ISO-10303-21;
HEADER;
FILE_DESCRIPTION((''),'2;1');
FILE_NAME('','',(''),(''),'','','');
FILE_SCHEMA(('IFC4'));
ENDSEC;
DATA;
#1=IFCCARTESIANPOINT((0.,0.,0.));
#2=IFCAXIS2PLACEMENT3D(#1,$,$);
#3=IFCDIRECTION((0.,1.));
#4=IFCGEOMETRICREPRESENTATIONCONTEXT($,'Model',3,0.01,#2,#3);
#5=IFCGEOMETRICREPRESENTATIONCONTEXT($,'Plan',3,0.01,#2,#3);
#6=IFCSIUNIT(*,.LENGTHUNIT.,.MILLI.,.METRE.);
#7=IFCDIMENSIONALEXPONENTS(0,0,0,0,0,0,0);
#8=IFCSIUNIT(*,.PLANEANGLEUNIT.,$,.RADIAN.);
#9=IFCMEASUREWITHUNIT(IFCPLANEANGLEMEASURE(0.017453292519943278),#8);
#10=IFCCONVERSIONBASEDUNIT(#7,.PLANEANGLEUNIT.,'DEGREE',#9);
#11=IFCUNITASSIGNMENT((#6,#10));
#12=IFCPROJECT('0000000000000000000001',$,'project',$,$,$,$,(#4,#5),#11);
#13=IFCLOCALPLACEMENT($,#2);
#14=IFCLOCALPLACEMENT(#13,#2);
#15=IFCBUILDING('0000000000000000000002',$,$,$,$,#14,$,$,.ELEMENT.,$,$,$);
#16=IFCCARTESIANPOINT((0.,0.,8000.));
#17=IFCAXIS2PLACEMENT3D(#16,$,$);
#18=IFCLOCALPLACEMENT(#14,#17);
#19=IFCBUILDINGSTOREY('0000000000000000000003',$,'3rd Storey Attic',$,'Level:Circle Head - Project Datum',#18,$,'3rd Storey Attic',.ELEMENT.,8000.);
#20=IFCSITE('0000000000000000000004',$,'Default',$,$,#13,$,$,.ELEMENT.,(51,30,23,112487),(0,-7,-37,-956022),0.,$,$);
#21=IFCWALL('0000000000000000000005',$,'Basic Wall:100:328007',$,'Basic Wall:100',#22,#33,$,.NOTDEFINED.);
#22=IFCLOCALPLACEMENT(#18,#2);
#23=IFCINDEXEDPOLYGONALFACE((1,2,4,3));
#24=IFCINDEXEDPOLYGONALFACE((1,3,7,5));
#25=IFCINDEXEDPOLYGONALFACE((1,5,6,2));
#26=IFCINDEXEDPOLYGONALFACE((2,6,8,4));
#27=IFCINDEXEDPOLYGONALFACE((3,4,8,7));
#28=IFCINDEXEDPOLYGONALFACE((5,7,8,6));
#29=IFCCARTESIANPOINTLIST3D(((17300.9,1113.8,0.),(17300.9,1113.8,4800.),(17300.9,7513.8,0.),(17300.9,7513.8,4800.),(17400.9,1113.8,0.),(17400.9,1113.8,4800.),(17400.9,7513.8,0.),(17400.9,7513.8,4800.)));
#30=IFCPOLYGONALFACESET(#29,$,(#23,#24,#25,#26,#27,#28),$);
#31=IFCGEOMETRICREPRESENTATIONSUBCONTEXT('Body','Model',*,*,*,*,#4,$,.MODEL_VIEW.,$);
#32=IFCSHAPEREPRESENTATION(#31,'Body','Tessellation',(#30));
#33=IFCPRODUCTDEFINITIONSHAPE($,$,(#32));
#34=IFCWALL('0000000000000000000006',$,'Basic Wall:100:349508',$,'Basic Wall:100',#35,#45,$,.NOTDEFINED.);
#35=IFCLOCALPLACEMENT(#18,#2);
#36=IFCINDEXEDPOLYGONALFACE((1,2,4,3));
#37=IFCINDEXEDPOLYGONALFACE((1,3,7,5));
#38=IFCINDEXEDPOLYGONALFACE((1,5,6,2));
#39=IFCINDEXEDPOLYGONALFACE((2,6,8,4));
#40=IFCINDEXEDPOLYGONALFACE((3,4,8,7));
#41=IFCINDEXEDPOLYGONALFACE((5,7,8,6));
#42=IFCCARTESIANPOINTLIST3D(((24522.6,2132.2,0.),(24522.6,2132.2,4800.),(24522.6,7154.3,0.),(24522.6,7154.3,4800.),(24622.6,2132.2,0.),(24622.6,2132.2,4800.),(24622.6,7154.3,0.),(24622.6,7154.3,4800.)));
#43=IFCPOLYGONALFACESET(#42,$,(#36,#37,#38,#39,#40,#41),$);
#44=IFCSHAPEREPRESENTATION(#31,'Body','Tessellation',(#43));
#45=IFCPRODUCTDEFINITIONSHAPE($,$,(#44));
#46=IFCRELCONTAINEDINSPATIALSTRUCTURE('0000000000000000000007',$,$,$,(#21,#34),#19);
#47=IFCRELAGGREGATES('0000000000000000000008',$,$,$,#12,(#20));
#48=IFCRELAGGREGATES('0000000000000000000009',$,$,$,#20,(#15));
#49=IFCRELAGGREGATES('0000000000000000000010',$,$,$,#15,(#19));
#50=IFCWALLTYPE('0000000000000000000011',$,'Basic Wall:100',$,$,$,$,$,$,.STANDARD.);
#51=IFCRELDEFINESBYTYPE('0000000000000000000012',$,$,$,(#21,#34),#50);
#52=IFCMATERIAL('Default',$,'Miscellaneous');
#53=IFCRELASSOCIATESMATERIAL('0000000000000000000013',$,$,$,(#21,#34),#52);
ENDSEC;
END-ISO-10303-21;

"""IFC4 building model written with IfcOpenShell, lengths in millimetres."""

from ifc_helpers import new_model, entity, si_unit, converted_unit, direction, frame, origin, place, context, subcontext, project, spatial, indexed_curve, outline, extrude, material, type_object, element, save


model = new_model("IFC4")

# Units and contexts
model_context = context("Model", 3, precision=0.01, world=origin(), true_north=direction((0.0, 1.0)))
plan_context = context("Plan", 3, precision=0.01, world=origin(), true_north=direction((0.0, 1.0)))
body_context = subcontext(model_context, "Body", "Model", "MODEL_VIEW")
ifc_project = project(units=[si_unit("LENGTHUNIT", "METRE", prefix="MILLI"), converted_unit("PLANEANGLEUNIT", "DEGREE", entity("IfcPlaneAngleMeasure", 0.017453292519943278), si_unit("PLANEANGLEUNIT", "RADIAN"), dimensions=[0, 0, 0, 0, 0, 0, 0])], contexts=[model_context, plan_context])

# Site, building, storey
site_placement = place(None, origin())
site = spatial("IfcSite", under=ifc_project, at=site_placement, Name="Default", CompositionType="ELEMENT", RefLatitude=(51, 30, 23, 112487), RefLongitude=(0, -7, -37, -956022), RefElevation=0.0)
building_placement = place(site_placement, origin())
building = spatial("IfcBuilding", under=site, at=building_placement, CompositionType="ELEMENT")
storey_placement = place(building_placement, frame((0.0, 0.0, 8000.0)))
storey = spatial("IfcBuildingStorey", under=building, at=storey_placement, Name="3rd Storey Attic", ObjectType="Level:Circle Head - Project Datum", LongName="3rd Storey Attic", CompositionType="ELEMENT", Elevation=8000.0)

# Shared definitions
ifc_material_1 = material(Name="Default", Category="Miscellaneous")

# Walls
wall_type = type_object("IfcWallType", Name="Basic Wall:100", PredefinedType="STANDARD")
wall_1_placement = place(storey_placement, frame((17350.9, 1113.8, 0.0), z_axis=(0.0, 0.0, 1.0), x_axis=(0.0, 1.0, 0.0)))
element("IfcWall", 1, at=wall_1_placement, inside=storey, type_object=wall_type, material=ifc_material_1, Name="Basic Wall:100:328007", ObjectType="Basic Wall:100", PredefinedType="NOTDEFINED", context=body_context, shape_type="SweptSolid", body=[
    extrude(outline(indexed_curve([(6400.0, 50.0), (0.0, 50.0), (0.0, -50.0), (6400.0, -50.0), (6400.0, 50.0)], self_intersect=False)), origin(), (0.0, 0.0, 1.0), 4800.0),
])
wall_2_placement = place(storey_placement, frame((24572.6, 2132.2, 0.0), z_axis=(0.0, 0.0, 1.0), x_axis=(0.0, 1.0, 0.0)))
element("IfcWall", 2, at=wall_2_placement, inside=storey, type_object=wall_type, material=ifc_material_1, Name="Basic Wall:100:349508", ObjectType="Basic Wall:100", PredefinedType="NOTDEFINED", context=body_context, shape_type="SweptSolid", body=[
    extrude(outline(indexed_curve([(5022.1, 50.0), (0.0, 50.0), (0.0, -50.0), (5022.1, -50.0), (5022.1, 50.0)], self_intersect=False)), origin(), (0.0, 0.0, 1.0), 4800.0),
])

save(model, "model.ifc")
